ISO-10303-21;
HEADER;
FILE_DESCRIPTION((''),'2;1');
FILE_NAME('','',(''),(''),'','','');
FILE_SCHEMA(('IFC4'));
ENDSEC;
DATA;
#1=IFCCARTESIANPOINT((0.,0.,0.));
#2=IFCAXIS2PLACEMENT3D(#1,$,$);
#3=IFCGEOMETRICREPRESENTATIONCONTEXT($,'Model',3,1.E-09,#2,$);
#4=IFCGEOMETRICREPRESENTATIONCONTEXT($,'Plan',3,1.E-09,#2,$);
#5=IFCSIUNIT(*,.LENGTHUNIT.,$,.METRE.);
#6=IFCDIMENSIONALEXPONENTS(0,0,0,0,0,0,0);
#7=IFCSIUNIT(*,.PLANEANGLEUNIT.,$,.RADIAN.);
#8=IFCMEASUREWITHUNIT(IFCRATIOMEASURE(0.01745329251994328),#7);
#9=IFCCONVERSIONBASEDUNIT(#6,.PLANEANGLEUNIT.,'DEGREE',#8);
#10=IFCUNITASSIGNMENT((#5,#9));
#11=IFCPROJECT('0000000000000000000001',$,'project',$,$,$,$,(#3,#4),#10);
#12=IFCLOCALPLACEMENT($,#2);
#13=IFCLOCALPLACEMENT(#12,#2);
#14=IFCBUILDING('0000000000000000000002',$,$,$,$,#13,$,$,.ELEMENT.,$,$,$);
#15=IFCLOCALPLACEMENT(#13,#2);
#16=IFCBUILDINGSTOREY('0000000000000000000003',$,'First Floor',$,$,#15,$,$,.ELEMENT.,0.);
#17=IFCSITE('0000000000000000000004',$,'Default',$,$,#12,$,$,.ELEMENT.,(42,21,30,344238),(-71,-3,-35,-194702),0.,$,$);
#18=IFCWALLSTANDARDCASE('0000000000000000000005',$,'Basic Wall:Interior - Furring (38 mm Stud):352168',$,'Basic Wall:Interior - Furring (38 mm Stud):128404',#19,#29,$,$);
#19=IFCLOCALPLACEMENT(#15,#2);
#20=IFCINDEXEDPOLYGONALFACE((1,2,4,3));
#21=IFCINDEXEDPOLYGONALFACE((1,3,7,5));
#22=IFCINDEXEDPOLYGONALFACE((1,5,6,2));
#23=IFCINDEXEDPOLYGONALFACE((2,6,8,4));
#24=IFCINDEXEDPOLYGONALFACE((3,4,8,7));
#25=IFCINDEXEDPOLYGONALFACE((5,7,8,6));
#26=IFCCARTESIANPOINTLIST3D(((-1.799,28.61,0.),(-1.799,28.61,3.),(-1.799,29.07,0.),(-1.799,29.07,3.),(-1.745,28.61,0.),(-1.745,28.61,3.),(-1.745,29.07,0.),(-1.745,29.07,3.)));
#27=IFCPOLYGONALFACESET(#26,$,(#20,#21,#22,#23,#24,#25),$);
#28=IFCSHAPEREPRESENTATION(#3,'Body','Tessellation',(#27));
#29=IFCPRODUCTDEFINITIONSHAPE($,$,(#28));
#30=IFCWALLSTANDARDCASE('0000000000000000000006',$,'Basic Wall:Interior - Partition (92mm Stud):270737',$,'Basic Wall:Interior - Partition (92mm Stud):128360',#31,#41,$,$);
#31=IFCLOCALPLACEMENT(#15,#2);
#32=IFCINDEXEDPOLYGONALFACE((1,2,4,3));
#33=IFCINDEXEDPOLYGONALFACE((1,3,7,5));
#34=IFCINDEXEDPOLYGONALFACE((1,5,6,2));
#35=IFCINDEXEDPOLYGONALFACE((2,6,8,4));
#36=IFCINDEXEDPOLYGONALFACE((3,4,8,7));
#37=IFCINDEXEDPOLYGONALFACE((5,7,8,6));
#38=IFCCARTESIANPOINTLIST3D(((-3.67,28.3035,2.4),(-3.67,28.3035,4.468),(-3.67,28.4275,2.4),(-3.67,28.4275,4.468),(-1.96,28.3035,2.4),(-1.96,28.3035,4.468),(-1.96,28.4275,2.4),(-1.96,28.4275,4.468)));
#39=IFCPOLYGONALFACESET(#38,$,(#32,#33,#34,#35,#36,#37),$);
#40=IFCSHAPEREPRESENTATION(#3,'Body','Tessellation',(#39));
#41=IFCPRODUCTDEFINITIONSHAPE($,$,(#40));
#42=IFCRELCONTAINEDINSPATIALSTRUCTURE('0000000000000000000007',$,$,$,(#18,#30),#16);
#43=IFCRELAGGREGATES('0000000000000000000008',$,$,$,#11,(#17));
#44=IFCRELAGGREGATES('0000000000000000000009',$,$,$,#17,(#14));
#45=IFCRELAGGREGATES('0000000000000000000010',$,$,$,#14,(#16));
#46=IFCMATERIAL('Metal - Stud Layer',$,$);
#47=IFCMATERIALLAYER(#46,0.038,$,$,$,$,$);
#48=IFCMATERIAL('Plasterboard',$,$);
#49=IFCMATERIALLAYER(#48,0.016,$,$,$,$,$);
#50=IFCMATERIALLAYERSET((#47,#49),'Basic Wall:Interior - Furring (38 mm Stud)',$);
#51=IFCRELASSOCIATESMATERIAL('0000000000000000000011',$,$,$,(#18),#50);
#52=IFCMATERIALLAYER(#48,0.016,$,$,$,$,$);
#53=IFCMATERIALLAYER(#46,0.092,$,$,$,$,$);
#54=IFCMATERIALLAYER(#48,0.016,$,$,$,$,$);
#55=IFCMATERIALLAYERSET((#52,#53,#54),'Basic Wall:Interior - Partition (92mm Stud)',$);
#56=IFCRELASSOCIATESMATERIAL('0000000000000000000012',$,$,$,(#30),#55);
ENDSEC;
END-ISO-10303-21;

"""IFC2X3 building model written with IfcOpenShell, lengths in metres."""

from ifc_helpers import new_model, entity, si_unit, converted_unit, frame, frame_2d, origin, place, context, project, spatial, rectangle, extrude, material, layer, layer_set, layer_usage, element, save


model = new_model("IFC2X3")

# Units and contexts
model_context = context("Model", 3, precision=1e-09, world=origin())
plan_context = context("Plan", 3, precision=1e-09, world=origin())
ifc_project = project(units=[si_unit("LENGTHUNIT", "METRE"), converted_unit("PLANEANGLEUNIT", "DEGREE", entity("IfcRatioMeasure", 0.01745329251994328), si_unit("PLANEANGLEUNIT", "RADIAN"), dimensions=[0, 0, 0, 0, 0, 0, 0])], contexts=[model_context, plan_context])

# Site, building, storey
site_placement = place(None, origin())
site = spatial("IfcSite", under=ifc_project, at=site_placement, Name="Default", CompositionType="ELEMENT", RefLatitude=(42, 21, 30, 344238), RefLongitude=(-71, -3, -35, -194702), RefElevation=0.0)
building_placement = place(site_placement, origin())
building = spatial("IfcBuilding", under=site, at=building_placement, CompositionType="ELEMENT")
storey_placement = place(building_placement, origin())
storey = spatial("IfcBuildingStorey", under=building, at=storey_placement, Name="First Floor", CompositionType="ELEMENT", Elevation=0.0)

# Shared definitions
ifc_material_1 = material(Name="Plasterboard")
ifc_layer_1 = layer(ifc_material_1, 0.016)
ifc_material_2 = material(Name="Metal - Stud Layer")
ifc_layer_2 = layer(ifc_material_2, 0.092)
ifc_layer_3 = layer(ifc_material_1, 0.016)
ifc_layer_set_1 = layer_set([ifc_layer_1, ifc_layer_2, ifc_layer_3], Name="Basic Wall:Interior - Partition (92mm Stud)")
ifc_layer_usage_1 = layer_usage(ifc_layer_set_1, "AXIS2", "NEGATIVE", 0.062)

# Walls
ifc_layer_4 = layer(ifc_material_2, 0.038)
ifc_layer_5 = layer(ifc_material_1, 0.016)
ifc_layer_set_2 = layer_set([ifc_layer_4, ifc_layer_5], Name="Basic Wall:Interior - Furring (38 mm Stud)")
ifc_layer_usage_2 = layer_usage(ifc_layer_set_2, "AXIS2", "POSITIVE", -0.027)
wall_1_placement = place(storey_placement, frame((-1.772, 29.07, 0.0), z_axis=(0.0, 0.0, 1.0), x_axis=(0.0, -1.0, 0.0)))
element("IfcWallStandardCase", 1, at=wall_1_placement, inside=storey, material=ifc_layer_usage_2, Name="Basic Wall:Interior - Furring (38 mm Stud):352168", ObjectType="Basic Wall:Interior - Furring (38 mm Stud):128404", context=model_context, shape_type="SweptSolid", body=[
    extrude(rectangle(XDim=0.46, YDim=0.054, at=frame_2d((0.23, 0.0), x_axis=(-1.0, 0.0))), origin(), (0.0, 0.0, 1.0), 3.0),
])
wall_2_placement = place(storey_placement, frame((-1.96, 28.3655, 2.4), z_axis=(0.0, 0.0, 1.0), x_axis=(-1.0, 0.0, 0.0)))
element("IfcWallStandardCase", 2, at=wall_2_placement, inside=storey, material=ifc_layer_usage_1, Name="Basic Wall:Interior - Partition (92mm Stud):270737", ObjectType="Basic Wall:Interior - Partition (92mm Stud):128360", context=model_context, shape_type="SweptSolid", body=[
    extrude(rectangle(XDim=1.71, YDim=0.124, at=frame_2d((0.855, 0.0), x_axis=(-1.0, 0.0))), origin(), (0.0, 0.0, 1.0), 2.068),
])

save(model, "model.ifc")
